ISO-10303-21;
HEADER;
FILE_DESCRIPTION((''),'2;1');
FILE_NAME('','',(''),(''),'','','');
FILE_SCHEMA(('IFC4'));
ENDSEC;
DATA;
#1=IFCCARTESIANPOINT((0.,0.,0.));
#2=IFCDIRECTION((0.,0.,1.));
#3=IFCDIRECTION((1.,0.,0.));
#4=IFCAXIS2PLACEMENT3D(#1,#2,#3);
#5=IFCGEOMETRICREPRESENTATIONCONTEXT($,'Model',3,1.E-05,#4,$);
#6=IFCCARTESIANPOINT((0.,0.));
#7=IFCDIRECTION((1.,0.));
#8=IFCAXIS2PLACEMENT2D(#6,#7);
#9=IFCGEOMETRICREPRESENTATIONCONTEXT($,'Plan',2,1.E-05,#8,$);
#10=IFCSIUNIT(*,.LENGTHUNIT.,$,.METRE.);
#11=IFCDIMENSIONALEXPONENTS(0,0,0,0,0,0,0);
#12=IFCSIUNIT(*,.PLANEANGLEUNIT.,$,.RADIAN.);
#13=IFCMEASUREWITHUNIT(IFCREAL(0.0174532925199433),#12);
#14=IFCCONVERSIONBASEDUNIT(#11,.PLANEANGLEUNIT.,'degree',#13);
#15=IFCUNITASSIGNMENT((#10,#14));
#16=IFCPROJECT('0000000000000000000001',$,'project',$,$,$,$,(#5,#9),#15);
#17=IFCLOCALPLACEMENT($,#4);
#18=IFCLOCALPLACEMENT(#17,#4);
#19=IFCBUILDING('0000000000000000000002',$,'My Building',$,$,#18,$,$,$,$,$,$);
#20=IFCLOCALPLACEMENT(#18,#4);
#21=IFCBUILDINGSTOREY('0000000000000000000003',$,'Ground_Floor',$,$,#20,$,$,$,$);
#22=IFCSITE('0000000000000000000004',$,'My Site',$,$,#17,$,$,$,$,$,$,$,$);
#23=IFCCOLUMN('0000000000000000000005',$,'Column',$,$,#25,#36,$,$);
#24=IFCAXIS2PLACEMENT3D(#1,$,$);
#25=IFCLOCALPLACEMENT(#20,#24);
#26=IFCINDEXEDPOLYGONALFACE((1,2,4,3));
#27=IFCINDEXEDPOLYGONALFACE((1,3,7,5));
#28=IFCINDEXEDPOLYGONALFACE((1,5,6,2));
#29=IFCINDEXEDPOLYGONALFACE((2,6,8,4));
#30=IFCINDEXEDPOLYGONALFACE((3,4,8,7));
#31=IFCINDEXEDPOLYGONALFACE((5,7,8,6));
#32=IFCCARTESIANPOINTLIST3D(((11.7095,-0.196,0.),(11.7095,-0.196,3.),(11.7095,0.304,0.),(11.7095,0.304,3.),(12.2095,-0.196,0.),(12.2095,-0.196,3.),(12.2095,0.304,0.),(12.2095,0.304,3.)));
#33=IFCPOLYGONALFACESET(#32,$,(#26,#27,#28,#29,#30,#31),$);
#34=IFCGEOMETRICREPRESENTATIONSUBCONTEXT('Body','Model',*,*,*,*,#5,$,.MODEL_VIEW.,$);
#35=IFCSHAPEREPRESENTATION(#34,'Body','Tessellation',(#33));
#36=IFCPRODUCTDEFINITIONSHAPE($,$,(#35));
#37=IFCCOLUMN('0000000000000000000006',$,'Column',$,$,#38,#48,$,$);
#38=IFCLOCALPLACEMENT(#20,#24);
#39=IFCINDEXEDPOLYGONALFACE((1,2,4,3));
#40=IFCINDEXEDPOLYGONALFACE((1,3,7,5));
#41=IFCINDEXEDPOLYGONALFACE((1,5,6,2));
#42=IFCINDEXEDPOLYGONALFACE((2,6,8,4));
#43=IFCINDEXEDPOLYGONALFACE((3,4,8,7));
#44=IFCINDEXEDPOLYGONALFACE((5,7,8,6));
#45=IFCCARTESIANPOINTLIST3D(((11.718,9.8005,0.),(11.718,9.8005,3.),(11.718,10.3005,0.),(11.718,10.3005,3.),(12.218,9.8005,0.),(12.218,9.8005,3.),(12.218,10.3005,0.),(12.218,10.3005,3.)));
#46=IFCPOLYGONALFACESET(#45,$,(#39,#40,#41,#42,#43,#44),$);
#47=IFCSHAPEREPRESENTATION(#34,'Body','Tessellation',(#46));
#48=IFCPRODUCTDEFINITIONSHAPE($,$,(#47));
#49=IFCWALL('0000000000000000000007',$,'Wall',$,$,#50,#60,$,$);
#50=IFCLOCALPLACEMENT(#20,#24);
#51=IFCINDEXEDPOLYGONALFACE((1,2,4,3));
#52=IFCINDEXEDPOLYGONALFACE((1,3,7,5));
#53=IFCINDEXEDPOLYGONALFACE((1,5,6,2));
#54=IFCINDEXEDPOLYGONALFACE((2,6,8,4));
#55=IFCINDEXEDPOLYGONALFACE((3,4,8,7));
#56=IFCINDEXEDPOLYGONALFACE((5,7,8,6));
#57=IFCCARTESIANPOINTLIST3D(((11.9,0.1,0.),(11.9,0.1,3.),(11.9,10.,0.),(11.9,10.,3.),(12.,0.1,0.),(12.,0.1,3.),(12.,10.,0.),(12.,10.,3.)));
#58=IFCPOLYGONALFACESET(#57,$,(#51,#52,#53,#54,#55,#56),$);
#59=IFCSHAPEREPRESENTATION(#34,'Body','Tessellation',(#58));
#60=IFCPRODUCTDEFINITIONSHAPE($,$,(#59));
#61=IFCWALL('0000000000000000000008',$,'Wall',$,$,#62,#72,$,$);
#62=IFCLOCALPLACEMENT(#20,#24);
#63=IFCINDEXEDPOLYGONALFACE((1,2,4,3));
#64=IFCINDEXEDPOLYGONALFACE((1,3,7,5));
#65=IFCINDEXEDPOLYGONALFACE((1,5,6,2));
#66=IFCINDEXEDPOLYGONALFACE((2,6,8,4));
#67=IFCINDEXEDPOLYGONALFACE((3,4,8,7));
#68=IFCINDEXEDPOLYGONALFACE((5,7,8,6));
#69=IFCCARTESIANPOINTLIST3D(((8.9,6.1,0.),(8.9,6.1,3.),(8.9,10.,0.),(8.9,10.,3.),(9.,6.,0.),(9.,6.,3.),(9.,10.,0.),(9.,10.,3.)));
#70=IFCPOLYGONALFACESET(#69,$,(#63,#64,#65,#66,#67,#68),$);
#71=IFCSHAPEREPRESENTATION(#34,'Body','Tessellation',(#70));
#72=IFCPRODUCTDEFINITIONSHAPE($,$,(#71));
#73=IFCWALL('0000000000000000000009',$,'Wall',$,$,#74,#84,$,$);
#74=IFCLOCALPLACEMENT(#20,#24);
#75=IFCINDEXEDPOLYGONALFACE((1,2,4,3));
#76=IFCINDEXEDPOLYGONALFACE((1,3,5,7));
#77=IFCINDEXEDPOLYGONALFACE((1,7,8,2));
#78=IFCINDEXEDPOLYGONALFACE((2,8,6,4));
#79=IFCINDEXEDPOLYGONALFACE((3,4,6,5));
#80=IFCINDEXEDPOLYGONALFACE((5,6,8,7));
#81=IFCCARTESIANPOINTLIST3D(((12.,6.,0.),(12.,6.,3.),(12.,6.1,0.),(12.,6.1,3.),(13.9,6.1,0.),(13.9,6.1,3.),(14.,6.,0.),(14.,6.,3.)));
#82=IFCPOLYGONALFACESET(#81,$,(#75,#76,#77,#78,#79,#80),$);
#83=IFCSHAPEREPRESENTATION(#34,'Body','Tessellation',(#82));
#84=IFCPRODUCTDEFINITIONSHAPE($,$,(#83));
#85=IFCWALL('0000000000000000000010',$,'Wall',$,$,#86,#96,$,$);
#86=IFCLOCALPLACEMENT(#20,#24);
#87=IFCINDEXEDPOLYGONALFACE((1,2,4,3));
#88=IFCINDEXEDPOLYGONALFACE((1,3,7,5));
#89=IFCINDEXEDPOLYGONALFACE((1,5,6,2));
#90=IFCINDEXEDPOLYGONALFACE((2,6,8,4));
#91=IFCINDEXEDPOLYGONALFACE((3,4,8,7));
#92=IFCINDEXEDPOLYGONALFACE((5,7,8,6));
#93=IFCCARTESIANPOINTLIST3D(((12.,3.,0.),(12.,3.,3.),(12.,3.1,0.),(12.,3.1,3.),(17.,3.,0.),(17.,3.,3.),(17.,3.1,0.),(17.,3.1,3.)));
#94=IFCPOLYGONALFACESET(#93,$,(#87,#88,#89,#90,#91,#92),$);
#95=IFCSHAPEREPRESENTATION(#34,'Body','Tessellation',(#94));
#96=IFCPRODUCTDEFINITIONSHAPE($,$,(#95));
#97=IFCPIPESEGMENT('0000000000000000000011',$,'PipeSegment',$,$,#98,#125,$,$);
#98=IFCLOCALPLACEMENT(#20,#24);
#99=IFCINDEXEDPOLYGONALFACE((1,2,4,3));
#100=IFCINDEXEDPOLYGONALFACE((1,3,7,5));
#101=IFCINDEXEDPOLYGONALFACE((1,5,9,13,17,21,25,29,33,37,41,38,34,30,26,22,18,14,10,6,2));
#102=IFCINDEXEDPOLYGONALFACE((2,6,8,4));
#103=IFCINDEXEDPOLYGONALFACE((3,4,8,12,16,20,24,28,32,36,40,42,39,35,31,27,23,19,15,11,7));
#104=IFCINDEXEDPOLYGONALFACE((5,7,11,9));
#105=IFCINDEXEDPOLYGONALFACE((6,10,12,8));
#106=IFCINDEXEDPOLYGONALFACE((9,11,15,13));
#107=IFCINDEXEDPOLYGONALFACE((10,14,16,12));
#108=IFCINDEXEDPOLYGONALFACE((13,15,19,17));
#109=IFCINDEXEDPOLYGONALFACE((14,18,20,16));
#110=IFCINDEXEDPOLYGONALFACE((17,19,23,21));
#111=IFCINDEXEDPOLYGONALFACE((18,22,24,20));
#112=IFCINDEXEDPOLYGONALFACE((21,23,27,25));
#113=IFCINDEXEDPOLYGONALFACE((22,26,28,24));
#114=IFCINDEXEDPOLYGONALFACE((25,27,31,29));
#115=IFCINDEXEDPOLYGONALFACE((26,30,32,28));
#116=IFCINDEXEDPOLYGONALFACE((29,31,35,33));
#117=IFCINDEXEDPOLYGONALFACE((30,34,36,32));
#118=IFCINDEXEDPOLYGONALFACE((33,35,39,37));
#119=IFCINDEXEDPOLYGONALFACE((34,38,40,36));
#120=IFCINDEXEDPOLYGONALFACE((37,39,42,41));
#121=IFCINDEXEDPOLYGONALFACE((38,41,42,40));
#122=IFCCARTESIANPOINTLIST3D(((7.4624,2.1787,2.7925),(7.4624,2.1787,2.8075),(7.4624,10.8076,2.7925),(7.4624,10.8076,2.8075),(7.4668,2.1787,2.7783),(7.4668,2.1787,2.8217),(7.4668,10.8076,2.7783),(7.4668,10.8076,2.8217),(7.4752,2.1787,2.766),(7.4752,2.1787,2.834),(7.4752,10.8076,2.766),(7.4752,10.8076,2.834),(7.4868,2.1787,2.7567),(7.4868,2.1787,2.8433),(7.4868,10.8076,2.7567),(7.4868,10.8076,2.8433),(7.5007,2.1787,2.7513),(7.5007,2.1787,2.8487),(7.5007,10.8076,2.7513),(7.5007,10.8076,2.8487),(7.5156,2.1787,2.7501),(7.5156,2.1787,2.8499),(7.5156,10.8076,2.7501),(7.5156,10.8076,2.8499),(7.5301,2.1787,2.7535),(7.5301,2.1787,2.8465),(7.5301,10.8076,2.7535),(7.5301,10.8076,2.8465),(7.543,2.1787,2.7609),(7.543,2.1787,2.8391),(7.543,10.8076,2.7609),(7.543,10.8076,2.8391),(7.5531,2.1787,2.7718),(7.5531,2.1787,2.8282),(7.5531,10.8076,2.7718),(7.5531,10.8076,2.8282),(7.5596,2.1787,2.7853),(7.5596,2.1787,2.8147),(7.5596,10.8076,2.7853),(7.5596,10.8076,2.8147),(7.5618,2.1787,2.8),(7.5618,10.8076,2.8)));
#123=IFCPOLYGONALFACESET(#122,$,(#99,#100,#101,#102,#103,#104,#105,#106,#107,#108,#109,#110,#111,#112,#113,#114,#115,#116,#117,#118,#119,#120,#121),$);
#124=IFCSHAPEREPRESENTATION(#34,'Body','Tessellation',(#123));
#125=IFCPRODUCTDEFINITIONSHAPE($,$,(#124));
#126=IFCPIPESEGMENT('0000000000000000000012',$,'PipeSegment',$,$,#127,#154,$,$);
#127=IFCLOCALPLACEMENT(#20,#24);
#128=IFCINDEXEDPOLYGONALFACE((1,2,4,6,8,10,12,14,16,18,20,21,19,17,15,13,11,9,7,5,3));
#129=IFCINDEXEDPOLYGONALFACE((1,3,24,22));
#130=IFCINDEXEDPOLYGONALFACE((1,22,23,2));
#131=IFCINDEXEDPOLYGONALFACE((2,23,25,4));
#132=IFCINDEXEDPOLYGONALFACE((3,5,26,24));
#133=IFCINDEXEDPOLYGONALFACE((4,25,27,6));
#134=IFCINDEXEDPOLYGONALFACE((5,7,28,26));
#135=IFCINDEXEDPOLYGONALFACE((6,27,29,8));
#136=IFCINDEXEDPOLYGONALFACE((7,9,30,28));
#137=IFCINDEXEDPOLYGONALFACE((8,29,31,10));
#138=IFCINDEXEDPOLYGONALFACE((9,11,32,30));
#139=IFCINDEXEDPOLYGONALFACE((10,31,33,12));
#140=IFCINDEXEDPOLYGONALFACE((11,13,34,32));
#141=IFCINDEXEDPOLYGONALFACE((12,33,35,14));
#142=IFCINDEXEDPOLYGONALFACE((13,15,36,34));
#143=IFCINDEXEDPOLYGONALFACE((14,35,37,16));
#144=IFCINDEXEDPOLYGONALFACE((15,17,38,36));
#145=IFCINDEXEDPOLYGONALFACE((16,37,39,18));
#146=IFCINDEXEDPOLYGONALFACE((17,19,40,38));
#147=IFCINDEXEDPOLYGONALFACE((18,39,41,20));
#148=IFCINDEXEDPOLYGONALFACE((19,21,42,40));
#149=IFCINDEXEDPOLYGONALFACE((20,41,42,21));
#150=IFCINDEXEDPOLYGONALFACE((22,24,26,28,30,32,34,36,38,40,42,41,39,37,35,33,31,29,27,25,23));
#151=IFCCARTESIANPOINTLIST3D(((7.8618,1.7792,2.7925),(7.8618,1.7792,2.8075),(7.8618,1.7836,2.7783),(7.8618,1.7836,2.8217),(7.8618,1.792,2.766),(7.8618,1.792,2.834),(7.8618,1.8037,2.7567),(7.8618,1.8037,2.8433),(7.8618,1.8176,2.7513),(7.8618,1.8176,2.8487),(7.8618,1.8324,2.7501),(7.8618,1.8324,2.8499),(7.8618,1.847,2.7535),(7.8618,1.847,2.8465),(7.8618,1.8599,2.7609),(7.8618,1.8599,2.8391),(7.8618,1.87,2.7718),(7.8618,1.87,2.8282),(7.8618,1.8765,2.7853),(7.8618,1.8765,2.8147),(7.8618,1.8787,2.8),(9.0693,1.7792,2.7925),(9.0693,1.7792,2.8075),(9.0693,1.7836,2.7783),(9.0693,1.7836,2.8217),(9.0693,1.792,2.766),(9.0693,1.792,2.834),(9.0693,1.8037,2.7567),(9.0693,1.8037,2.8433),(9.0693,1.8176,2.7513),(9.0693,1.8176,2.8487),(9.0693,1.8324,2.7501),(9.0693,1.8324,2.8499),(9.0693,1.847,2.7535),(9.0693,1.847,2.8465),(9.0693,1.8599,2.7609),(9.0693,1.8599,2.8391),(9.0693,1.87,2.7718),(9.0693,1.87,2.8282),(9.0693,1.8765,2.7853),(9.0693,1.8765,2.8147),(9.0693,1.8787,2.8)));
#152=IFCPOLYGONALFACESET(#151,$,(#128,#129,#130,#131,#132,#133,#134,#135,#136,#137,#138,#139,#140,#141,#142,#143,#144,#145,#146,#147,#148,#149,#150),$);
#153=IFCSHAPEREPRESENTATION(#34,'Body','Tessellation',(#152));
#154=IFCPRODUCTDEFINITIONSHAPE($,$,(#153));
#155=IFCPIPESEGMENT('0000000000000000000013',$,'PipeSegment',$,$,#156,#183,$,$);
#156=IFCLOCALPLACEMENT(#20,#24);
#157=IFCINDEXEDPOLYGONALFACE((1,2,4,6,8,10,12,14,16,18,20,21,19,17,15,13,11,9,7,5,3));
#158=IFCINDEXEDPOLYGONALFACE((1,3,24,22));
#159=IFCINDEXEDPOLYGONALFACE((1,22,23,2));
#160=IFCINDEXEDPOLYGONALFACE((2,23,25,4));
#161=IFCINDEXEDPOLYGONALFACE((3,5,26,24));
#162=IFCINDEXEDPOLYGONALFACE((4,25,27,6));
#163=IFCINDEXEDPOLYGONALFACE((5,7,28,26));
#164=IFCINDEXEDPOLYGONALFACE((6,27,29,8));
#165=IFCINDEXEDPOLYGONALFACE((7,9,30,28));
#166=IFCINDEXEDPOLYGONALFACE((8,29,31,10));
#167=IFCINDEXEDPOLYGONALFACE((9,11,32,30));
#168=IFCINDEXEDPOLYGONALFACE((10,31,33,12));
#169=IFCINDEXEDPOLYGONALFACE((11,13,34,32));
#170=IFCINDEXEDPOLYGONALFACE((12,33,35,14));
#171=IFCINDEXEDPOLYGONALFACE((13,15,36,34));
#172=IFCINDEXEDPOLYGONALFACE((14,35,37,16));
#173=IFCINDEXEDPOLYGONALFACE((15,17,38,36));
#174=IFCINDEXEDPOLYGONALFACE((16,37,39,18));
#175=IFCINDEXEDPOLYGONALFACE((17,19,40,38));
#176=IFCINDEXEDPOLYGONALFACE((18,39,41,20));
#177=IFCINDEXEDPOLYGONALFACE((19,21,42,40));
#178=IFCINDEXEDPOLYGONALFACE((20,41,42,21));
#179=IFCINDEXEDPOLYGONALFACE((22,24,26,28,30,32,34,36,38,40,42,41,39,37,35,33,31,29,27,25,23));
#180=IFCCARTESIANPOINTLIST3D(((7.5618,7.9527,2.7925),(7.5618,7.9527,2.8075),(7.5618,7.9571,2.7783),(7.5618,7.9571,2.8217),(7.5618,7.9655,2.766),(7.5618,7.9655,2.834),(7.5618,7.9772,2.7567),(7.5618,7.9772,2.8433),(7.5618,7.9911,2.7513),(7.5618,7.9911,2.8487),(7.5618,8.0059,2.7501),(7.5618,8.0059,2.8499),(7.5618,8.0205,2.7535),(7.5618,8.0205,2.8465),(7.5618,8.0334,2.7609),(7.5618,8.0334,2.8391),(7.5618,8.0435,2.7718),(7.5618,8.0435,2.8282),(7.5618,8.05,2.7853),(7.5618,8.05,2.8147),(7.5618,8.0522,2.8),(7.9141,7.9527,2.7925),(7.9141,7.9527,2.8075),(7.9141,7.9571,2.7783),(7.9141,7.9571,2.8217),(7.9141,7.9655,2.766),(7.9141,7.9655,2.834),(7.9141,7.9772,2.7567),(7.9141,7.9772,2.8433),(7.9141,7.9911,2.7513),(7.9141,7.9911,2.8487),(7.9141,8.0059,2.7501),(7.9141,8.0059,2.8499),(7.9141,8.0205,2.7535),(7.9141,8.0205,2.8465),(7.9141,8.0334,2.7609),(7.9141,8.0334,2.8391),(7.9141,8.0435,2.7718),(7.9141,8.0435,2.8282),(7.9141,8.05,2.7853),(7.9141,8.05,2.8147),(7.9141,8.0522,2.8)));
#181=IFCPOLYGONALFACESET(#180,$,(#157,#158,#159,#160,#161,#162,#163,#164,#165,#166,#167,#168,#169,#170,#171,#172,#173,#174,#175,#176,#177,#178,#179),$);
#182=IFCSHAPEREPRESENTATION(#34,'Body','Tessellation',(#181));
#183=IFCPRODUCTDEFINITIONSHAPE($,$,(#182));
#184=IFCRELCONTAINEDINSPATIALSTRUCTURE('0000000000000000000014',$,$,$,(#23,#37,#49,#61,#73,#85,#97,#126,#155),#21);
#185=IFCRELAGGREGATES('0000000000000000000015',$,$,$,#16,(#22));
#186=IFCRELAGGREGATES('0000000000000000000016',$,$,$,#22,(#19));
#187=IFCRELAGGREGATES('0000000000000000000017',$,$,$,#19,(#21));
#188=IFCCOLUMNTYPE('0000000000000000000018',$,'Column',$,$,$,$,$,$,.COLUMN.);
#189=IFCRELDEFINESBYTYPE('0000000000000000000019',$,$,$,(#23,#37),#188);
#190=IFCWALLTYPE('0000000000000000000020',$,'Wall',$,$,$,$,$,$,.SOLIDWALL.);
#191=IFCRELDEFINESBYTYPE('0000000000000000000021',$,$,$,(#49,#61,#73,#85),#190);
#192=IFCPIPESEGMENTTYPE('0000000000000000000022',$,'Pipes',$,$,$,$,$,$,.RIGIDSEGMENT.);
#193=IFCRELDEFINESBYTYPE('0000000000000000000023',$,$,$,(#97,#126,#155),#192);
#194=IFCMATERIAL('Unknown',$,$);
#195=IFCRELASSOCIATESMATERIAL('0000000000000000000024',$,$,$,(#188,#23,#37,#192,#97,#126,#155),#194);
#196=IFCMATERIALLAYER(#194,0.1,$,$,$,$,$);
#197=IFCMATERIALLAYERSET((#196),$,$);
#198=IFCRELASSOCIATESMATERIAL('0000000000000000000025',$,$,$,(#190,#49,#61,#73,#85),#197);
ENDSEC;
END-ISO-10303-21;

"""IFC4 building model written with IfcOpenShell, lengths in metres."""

from ifc_helpers import new_model, entity, si_unit, converted_unit, frame, origin_with_axes, origin_2d_with_axis, place, context, subcontext, project, spatial, line, indexed_curve, rectangle, circle, outline, extrude, material, layer, layer_set, layer_usage, material_profile, profile_set, profile_usage, type_object, element, save


model = new_model("IFC4")

# Units and contexts
model_context = context("Model", 3, precision=1e-05, world=origin_with_axes())
plan_context = context("Plan", 2, precision=1e-05, world=origin_2d_with_axis())
body_context = subcontext(model_context, "Body", "Model", "MODEL_VIEW")
ifc_project = project(units=[si_unit("LENGTHUNIT", "METRE"), converted_unit("PLANEANGLEUNIT", "degree", entity("IfcReal", 0.0174532925199433), si_unit("PLANEANGLEUNIT", "RADIAN"), dimensions=[0, 0, 0, 0, 0, 0, 0])], contexts=[model_context, plan_context])

# Site, building, storey
site_placement = place(None, origin_with_axes())
site = spatial("IfcSite", under=ifc_project, at=site_placement, Name="My Site")
building_placement = place(site_placement, origin_with_axes())
building = spatial("IfcBuilding", under=site, at=building_placement, Name="My Building")
storey_placement = place(building_placement, origin_with_axes())
storey = spatial("IfcBuildingStorey", under=building, at=storey_placement, Name="Ground_Floor")

# Columns
ifc_material = material(Name="Unknown")
ifc_material_profile_1 = material_profile(ifc_material, rectangle(XDim=0.5, YDim=0.5))
ifc_profile_set_1 = profile_set([ifc_material_profile_1])
ifc_profile_usage_1 = profile_usage(ifc_profile_set_1, cardinal=5)
column_type = type_object("IfcColumnType", Name="Column", PredefinedType="COLUMN", material=ifc_profile_set_1)
column_1_placement = place(storey_placement, frame((11.9595, 0.054, 0.0), z_axis=(0.0, 0.0, 1.0), x_axis=(1.0, 0.0, 0.0)))
element("IfcColumn", 1, at=column_1_placement, inside=storey, type_object=column_type, material=ifc_profile_usage_1, Name="Column", context=body_context, shape_type="SweptSolid", body=[
    extrude(rectangle(XDim=0.5, YDim=0.5), origin_with_axes(), (0.0, 0.0, 1.0), 3.0),
])
ifc_profile_usage_2 = profile_usage(ifc_profile_set_1, cardinal=5)
column_2_placement = place(storey_placement, frame((11.968, 10.0505, 0.0), z_axis=(0.0, 0.0, 1.0), x_axis=(1.0, 0.0, 0.0)))
element("IfcColumn", 2, at=column_2_placement, inside=storey, type_object=column_type, material=ifc_profile_usage_2, Name="Column", context=body_context, shape_type="SweptSolid", body=[
    extrude(rectangle(XDim=0.5, YDim=0.5), origin_with_axes(), (0.0, 0.0, 1.0), 3.0),
])

# Walls
ifc_layer = layer(ifc_material, 0.1)
ifc_layer_set = layer_set([ifc_layer])
ifc_layer_usage_1 = layer_usage(ifc_layer_set, "AXIS2", "POSITIVE", 0.0)
wall_type = type_object("IfcWallType", Name="Wall", PredefinedType="SOLIDWALL", material=ifc_layer_set)
wall_1_placement = place(storey_placement, frame((12.0, 0.0, 0.0), z_axis=(0.0, 0.0, 1.0), x_axis=(0.0, 1.0, 0.0)))
element("IfcWall", 3, at=wall_1_placement, inside=storey, type_object=wall_type, material=ifc_layer_usage_1, Name="Wall", context=body_context, shape_type="SweptSolid", body=[
    extrude(outline(indexed_curve([(0.1, 0.0), (0.1, 0.1), (10.0, 0.1), (10.0, 0.0)], segments=[line(1, 2, 3, 4, 1)])), origin_with_axes(), (0.0, 0.0, 1.0), 3.0),
])
ifc_layer_usage_2 = layer_usage(ifc_layer_set, "AXIS2", "POSITIVE", 0.0)
wall_2_placement = place(storey_placement, frame((9.0, 6.0, 0.0), z_axis=(0.0, 0.0, 1.0), x_axis=(0.0, 1.0, 0.0)))
element("IfcWall", 4, at=wall_2_placement, inside=storey, type_object=wall_type, material=ifc_layer_usage_2, Name="Wall", context=body_context, shape_type="SweptSolid", body=[
    extrude(outline(indexed_curve([(0.0, 0.0), (0.1, 0.1), (4.0, 0.1), (4.0, 0.0)], segments=[line(1, 2, 3, 4, 1)])), origin_with_axes(), (0.0, 0.0, 1.0), 3.0),
])
ifc_layer_usage_3 = layer_usage(ifc_layer_set, "AXIS2", "POSITIVE", 0.0)
wall_3_placement = place(storey_placement, frame((12.0, 6.0, 0.0), z_axis=(0.0, 0.0, 1.0), x_axis=(1.0, 0.0, 0.0)))
element("IfcWall", 5, at=wall_3_placement, inside=storey, type_object=wall_type, material=ifc_layer_usage_3, Name="Wall", context=body_context, shape_type="SweptSolid", body=[
    extrude(outline(indexed_curve([(0.0, 0.0), (0.0, 0.1), (1.9, 0.1), (2.0, 0.0)], segments=[line(1, 2, 3, 4, 1)])), origin_with_axes(), (0.0, 0.0, 1.0), 3.0),
])
ifc_layer_usage_4 = layer_usage(ifc_layer_set, "AXIS2", "POSITIVE", 0.0)
wall_4_placement = place(storey_placement, frame((12.0, 3.0, 0.0), z_axis=(0.0, 0.0, 1.0), x_axis=(1.0, 0.0, 0.0)))
element("IfcWall", 6, at=wall_4_placement, inside=storey, type_object=wall_type, material=ifc_layer_usage_4, Name="Wall", context=body_context, shape_type="SweptSolid", body=[
    extrude(outline(indexed_curve([(0.0, 0.0), (0.0, 0.1), (5.0, 0.1), (5.0, 0.0)], segments=[line(1, 2, 3, 4, 1)])), origin_with_axes(), (0.0, 0.0, 1.0), 3.0),
])

# Pipe segments
ifc_material_profile_2 = material_profile(ifc_material, circle(Radius=0.05))
ifc_profile_set_2 = profile_set([ifc_material_profile_2])
ifc_profile_usage_3 = profile_usage(ifc_profile_set_2, cardinal=5)
pipe_segment_type = type_object("IfcPipeSegmentType", Name="Pipes", PredefinedType="RIGIDSEGMENT", material=ifc_profile_set_2)
pipe_segment_1_placement = place(storey_placement, frame((7.5118, 10.8076, 2.8), z_axis=(0.0, -1.0, 0.0), x_axis=(1.0, 0.0, 0.0)))
element("IfcPipeSegment", 7, at=pipe_segment_1_placement, inside=storey, type_object=pipe_segment_type, material=ifc_profile_usage_3, Name="PipeSegment", context=body_context, shape_type="SweptSolid", body=[
    extrude(circle(Radius=0.05), origin_with_axes(), (0.0, 0.0, 1.0), 8.629),
])
ifc_profile_usage_4 = profile_usage(ifc_profile_set_2, cardinal=5)
pipe_segment_2_placement = place(storey_placement, frame((7.8618, 1.8287, 2.8), z_axis=(1.0, 0.0, 0.0), x_axis=(0.0, 1.0, 0.0)))
element("IfcPipeSegment", 8, at=pipe_segment_2_placement, inside=storey, type_object=pipe_segment_type, material=ifc_profile_usage_4, Name="PipeSegment", context=body_context, shape_type="SweptSolid", body=[
    extrude(circle(Radius=0.05), origin_with_axes(), (0.0, 0.0, 1.0), 1.2075),
])
ifc_profile_usage_5 = profile_usage(ifc_profile_set_2, cardinal=5)
pipe_segment_3_placement = place(storey_placement, frame((7.5618, 8.0022, 2.8), z_axis=(1.0, 0.0, 0.0), x_axis=(0.0, 1.0, 0.0)))
element("IfcPipeSegment", 9, at=pipe_segment_3_placement, inside=storey, type_object=pipe_segment_type, material=ifc_profile_usage_5, Name="PipeSegment", context=body_context, shape_type="SweptSolid", body=[
    extrude(circle(Radius=0.05), origin_with_axes(), (0.0, 0.0, 1.0), 0.3523),
])

save(model, "model.ifc")
